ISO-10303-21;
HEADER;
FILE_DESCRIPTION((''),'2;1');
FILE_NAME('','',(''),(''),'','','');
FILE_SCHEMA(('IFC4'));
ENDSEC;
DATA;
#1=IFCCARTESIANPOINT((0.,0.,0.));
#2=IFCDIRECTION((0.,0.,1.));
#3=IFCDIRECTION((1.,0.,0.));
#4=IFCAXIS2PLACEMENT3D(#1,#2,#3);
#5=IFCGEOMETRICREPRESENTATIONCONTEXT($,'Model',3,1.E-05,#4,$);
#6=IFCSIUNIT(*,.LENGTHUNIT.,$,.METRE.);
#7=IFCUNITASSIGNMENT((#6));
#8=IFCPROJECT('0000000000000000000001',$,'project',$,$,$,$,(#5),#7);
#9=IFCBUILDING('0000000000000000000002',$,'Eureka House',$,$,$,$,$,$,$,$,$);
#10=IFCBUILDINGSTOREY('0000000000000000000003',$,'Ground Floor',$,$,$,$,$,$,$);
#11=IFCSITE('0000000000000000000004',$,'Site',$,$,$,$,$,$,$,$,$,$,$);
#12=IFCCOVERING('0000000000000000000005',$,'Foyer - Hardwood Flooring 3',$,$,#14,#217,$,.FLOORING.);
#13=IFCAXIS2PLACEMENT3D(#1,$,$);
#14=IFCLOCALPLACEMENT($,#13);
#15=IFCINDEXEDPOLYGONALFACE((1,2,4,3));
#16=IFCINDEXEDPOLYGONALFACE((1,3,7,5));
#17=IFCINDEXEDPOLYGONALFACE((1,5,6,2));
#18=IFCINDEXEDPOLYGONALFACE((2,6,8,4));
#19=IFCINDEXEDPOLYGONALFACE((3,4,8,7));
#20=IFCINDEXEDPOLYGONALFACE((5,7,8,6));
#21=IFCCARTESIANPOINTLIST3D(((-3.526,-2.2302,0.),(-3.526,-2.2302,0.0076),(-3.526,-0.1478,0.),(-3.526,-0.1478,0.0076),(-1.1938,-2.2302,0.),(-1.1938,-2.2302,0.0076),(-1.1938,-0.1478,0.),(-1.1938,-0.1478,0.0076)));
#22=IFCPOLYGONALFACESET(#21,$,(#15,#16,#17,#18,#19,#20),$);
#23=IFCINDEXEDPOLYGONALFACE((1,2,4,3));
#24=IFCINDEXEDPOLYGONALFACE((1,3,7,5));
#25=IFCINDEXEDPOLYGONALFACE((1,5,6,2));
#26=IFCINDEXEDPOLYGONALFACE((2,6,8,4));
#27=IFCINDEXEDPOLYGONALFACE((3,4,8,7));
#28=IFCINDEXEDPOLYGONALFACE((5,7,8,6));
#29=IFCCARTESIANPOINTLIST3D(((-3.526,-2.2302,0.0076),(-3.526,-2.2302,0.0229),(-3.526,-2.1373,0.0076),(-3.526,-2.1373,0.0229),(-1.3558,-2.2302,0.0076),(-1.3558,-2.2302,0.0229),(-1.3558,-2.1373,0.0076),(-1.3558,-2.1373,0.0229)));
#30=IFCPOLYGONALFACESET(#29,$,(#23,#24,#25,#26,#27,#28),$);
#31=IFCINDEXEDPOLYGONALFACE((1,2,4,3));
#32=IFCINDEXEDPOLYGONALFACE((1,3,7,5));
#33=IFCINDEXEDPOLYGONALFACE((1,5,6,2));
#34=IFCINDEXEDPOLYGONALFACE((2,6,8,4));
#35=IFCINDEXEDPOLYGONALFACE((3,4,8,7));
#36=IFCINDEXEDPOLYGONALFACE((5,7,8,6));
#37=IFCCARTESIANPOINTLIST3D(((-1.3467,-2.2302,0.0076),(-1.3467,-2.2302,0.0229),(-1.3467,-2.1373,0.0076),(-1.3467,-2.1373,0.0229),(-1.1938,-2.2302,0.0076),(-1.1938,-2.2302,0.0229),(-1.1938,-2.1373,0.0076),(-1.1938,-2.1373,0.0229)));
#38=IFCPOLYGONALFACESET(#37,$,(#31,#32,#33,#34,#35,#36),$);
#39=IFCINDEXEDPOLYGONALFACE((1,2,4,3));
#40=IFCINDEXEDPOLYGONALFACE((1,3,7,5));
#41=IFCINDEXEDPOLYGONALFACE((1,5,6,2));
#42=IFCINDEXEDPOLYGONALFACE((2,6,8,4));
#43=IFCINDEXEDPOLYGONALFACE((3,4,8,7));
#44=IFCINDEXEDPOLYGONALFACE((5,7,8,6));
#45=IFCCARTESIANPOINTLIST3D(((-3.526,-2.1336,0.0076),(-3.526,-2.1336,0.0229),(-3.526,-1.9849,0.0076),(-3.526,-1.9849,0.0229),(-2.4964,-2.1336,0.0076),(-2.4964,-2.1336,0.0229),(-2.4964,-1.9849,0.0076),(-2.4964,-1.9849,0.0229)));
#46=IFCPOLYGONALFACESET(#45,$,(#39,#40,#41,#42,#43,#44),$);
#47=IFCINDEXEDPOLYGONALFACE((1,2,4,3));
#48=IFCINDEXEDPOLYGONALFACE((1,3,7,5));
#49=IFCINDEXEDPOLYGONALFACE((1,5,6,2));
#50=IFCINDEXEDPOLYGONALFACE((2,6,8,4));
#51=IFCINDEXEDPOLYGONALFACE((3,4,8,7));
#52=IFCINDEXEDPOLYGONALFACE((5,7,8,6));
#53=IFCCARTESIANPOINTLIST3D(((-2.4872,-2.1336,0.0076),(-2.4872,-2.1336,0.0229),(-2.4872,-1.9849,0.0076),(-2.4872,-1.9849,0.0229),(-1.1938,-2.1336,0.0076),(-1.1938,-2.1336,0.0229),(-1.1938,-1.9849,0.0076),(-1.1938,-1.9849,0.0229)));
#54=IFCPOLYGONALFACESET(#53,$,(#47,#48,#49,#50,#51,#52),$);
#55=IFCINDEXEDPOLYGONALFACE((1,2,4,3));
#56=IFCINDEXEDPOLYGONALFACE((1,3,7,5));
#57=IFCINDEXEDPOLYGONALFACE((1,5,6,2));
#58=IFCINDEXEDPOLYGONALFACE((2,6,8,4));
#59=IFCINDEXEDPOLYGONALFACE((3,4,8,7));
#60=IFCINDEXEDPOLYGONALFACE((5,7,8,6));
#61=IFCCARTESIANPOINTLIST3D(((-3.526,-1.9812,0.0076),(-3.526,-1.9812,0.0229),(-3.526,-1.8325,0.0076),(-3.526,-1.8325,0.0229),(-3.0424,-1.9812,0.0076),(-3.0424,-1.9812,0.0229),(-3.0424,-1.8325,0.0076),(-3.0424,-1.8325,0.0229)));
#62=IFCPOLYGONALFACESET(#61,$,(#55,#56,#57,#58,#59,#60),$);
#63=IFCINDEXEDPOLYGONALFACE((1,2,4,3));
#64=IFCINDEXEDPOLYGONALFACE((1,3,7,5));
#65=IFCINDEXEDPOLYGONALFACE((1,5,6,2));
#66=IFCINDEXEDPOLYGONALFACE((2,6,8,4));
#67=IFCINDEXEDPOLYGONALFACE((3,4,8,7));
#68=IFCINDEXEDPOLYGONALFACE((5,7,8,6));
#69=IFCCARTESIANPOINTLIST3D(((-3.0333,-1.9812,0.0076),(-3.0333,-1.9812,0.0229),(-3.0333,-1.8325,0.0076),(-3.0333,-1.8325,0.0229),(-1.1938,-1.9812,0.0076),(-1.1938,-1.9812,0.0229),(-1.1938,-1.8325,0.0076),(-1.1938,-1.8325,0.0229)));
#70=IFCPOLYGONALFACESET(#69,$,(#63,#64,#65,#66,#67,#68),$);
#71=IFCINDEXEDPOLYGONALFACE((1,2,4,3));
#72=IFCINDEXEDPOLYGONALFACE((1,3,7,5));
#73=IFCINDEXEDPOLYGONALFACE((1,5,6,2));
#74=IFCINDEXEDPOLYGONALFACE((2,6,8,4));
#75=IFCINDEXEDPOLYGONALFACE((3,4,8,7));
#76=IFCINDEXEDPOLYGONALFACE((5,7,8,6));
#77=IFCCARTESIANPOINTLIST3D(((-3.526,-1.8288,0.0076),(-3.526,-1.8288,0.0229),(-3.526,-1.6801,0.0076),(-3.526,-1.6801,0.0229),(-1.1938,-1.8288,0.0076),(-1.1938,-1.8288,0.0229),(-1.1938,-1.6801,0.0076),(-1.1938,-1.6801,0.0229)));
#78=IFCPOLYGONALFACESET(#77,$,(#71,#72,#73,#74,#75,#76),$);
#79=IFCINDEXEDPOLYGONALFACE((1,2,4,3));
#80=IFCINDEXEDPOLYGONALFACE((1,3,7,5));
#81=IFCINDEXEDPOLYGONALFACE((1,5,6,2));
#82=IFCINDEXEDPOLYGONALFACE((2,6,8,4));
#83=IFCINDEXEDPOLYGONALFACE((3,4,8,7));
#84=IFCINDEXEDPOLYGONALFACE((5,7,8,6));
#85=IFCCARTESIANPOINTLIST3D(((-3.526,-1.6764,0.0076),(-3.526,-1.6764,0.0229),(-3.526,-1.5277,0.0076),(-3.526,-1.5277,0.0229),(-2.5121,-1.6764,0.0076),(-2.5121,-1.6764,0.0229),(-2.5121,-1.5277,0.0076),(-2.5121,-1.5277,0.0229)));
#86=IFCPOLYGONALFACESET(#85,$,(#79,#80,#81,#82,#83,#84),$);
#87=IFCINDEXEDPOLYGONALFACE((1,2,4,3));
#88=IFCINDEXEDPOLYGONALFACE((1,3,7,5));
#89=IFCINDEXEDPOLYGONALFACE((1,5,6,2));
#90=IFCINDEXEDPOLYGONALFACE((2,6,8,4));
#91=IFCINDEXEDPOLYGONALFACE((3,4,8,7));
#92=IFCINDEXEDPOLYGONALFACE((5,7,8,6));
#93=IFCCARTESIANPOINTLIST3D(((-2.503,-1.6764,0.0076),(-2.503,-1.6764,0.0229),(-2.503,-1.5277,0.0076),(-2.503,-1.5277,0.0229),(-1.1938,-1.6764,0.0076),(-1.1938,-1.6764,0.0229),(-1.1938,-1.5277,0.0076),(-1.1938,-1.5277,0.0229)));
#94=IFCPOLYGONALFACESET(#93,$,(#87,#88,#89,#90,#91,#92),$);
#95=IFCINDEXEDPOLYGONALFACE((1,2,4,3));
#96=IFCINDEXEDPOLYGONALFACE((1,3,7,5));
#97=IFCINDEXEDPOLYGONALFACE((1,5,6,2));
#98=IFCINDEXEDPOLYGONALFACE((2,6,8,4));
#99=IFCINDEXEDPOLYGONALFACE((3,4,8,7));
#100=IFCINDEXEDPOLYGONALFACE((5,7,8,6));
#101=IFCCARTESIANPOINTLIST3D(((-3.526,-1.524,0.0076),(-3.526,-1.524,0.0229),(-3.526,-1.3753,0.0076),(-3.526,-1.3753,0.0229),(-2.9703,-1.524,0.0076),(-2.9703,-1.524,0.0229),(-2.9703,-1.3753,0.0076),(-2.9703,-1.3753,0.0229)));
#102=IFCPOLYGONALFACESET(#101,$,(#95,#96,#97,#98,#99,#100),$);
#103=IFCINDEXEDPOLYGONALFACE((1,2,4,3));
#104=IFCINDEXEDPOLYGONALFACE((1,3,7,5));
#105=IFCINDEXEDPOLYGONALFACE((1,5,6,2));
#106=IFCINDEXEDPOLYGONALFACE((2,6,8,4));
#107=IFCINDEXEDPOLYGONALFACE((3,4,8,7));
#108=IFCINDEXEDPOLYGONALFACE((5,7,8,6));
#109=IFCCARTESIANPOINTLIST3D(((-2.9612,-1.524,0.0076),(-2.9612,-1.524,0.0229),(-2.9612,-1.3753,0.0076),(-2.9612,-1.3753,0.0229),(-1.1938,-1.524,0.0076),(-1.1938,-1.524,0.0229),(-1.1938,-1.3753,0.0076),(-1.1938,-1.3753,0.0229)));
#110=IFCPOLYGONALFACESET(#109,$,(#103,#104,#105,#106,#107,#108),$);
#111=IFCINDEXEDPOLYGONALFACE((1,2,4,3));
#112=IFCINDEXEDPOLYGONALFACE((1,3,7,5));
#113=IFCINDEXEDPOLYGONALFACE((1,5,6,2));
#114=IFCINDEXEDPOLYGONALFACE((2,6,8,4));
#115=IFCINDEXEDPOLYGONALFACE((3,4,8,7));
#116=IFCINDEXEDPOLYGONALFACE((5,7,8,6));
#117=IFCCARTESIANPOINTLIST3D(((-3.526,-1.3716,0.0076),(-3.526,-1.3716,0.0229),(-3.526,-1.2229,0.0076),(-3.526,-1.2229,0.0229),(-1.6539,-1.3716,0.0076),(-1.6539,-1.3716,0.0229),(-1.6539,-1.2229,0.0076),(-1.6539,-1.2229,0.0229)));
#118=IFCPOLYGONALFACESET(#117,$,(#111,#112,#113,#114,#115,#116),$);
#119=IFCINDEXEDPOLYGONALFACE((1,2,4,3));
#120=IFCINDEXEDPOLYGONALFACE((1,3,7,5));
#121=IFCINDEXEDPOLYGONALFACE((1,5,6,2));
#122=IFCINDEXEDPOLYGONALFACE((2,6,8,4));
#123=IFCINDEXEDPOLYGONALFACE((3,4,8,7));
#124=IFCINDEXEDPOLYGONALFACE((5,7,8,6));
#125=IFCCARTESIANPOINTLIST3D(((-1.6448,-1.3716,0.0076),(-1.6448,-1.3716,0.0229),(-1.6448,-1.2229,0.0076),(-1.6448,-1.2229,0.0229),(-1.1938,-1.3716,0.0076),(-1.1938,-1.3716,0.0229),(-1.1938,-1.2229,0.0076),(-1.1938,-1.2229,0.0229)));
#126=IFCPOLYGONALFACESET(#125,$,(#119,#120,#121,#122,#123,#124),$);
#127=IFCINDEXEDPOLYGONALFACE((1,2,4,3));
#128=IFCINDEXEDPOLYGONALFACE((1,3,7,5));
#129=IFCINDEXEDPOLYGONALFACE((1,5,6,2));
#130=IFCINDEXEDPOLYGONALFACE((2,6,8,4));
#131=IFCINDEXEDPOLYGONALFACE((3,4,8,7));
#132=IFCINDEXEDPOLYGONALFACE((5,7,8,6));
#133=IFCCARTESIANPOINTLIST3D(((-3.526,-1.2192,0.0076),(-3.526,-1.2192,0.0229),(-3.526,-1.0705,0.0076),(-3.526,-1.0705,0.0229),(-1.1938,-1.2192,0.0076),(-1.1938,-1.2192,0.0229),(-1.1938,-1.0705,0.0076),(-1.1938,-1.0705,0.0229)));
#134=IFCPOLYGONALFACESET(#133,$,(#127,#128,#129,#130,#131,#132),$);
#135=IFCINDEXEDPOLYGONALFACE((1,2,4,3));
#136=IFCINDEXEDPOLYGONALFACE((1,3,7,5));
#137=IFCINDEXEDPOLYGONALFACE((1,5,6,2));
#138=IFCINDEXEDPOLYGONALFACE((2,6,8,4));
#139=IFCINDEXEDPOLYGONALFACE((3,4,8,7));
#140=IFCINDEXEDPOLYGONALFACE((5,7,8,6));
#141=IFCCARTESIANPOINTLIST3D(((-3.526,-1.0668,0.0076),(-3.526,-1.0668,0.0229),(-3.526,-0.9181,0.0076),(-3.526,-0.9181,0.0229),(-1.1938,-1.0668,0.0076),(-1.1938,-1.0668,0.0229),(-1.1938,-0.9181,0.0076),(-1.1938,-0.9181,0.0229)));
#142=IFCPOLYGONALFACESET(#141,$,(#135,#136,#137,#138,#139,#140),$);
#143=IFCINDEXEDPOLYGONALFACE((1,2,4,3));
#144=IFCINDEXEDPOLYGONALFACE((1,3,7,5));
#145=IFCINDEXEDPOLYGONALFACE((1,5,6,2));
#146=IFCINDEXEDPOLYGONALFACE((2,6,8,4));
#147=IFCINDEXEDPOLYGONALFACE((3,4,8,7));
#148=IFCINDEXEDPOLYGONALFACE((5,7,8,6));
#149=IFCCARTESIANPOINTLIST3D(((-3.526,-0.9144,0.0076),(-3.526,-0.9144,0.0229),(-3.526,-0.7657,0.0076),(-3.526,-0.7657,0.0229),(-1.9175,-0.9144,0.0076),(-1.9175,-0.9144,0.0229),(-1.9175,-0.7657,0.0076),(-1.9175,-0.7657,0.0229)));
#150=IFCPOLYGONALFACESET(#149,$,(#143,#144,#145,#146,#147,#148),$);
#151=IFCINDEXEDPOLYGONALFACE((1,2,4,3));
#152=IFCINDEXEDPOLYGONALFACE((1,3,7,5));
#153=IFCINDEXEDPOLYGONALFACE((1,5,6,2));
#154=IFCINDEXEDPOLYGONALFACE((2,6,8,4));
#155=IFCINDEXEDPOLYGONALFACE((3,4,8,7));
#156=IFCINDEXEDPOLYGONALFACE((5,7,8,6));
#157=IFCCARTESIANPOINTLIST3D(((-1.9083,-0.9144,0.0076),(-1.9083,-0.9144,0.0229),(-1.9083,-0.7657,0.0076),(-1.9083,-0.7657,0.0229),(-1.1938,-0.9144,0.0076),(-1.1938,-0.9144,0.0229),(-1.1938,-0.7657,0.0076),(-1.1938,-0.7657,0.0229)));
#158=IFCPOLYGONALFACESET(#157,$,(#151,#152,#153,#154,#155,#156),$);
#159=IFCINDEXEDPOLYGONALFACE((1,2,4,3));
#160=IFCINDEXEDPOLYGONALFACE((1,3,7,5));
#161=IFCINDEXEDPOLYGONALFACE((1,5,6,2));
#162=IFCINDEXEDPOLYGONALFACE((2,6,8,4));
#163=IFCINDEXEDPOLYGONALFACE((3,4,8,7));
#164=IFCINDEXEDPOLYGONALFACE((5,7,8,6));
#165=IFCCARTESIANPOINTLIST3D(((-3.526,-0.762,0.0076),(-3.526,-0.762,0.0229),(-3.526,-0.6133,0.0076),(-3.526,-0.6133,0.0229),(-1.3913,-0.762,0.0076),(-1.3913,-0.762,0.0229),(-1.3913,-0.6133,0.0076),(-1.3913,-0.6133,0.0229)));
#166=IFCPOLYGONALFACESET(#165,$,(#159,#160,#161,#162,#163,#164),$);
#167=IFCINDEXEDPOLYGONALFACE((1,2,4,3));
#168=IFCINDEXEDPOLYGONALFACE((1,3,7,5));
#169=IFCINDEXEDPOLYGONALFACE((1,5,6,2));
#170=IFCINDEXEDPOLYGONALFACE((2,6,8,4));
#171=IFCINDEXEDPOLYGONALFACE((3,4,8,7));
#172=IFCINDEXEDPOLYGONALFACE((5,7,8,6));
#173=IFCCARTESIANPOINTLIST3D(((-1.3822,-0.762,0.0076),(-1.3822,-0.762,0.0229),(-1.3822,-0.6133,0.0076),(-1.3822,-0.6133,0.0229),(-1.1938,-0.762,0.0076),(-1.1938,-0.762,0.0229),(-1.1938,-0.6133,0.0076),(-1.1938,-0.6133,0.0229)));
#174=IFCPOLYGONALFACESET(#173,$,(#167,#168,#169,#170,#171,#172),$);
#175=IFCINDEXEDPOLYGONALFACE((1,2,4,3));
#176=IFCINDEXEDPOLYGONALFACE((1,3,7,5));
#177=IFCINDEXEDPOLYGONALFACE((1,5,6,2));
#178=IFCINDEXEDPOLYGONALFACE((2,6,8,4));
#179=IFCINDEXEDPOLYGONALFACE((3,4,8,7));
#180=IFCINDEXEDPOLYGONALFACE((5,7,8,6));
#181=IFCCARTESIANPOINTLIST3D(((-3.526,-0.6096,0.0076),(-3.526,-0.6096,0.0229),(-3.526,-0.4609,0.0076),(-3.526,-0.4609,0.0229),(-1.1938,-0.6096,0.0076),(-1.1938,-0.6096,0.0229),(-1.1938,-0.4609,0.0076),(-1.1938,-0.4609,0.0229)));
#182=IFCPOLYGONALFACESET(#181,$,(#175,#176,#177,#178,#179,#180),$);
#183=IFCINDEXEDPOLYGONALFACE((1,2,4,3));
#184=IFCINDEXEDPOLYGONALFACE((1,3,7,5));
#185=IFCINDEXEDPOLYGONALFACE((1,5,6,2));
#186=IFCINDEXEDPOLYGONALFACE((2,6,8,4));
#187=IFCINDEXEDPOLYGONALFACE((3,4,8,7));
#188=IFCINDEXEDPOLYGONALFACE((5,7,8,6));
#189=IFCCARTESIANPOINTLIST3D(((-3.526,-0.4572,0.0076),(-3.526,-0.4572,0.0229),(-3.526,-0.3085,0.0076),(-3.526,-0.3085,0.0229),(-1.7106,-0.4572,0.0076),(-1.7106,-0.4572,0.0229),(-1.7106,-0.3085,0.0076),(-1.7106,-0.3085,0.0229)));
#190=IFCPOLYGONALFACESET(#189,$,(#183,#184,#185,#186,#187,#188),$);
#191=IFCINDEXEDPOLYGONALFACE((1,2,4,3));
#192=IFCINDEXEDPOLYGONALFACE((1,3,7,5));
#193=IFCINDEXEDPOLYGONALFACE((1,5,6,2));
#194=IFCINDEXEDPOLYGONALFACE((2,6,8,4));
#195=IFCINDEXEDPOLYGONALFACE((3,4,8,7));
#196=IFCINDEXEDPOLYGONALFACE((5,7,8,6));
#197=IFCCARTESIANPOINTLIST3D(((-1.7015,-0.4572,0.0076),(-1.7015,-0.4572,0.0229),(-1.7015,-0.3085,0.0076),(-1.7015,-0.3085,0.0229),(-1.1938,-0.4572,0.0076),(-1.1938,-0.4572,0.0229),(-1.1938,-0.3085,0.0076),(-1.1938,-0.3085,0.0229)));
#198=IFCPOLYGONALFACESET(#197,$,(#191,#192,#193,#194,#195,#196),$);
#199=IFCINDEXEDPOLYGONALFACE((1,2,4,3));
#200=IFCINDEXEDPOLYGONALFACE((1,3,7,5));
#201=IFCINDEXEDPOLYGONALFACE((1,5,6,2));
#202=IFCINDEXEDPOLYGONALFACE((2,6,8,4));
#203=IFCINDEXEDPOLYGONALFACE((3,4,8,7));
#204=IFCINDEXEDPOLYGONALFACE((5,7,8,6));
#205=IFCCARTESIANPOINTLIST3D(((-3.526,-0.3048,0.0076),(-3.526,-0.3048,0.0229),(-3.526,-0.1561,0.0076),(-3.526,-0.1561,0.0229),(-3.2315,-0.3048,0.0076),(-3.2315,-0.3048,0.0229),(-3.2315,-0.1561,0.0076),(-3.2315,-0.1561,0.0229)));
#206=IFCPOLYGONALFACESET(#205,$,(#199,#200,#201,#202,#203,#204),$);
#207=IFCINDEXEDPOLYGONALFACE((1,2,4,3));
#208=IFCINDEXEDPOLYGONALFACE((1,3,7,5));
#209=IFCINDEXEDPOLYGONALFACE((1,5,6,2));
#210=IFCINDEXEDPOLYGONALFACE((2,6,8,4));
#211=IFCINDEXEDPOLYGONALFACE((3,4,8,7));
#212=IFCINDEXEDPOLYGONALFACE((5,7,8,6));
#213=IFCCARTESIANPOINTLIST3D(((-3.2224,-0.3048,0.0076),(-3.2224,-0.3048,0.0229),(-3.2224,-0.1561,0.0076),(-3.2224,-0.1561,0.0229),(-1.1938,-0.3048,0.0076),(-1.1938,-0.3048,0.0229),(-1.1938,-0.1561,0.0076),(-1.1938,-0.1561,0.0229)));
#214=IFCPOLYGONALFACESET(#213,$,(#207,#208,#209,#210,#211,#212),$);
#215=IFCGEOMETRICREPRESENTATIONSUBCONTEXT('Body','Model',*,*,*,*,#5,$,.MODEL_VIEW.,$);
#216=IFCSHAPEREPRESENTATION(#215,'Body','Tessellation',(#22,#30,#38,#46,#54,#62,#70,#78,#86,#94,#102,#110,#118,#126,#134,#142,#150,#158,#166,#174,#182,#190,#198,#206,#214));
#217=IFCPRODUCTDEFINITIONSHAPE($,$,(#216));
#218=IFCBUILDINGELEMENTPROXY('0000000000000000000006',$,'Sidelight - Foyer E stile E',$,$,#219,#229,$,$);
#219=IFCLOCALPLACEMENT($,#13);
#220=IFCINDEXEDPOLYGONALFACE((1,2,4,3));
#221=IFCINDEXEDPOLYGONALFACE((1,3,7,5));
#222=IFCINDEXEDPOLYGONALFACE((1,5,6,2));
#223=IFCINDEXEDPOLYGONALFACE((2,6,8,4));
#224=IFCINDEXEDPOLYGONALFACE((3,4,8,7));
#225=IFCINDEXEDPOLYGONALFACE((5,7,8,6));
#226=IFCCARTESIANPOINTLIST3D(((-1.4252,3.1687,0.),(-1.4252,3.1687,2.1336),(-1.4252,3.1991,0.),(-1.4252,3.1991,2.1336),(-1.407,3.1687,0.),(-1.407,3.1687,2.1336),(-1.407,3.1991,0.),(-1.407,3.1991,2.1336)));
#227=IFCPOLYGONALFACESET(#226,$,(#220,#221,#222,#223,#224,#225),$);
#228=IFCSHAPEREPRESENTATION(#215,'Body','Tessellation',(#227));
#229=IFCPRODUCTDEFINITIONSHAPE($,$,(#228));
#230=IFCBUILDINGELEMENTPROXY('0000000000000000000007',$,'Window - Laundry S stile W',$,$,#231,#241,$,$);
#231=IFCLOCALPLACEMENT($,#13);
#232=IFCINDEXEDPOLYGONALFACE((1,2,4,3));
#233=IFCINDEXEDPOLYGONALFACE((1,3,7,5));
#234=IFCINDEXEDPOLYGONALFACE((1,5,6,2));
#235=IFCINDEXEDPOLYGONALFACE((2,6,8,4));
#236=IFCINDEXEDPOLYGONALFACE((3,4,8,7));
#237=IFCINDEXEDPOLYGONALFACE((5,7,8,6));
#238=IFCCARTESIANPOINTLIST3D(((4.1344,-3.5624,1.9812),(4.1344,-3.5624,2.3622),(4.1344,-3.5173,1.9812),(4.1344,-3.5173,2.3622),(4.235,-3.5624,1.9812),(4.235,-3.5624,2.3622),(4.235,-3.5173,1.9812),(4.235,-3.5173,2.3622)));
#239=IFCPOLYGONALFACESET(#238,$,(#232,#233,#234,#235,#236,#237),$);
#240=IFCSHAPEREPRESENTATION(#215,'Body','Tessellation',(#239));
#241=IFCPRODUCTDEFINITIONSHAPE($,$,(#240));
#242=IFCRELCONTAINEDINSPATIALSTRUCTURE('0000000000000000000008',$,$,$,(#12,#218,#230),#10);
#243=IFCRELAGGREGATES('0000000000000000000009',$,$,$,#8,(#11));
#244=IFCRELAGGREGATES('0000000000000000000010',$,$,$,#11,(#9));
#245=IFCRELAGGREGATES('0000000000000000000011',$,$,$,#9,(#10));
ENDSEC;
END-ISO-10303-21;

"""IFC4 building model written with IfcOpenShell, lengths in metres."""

from ifc_helpers import new_model, si_unit, frame, origin, origin_with_axes, origin_2d, place, context, subcontext, project, spatial, rectangle, extrude, element, save


model = new_model("IFC4")

# Units and contexts
model_context = context("Model", 3, precision=1e-05, world=origin_with_axes())
body_context = subcontext(model_context, "Body", "Model", "MODEL_VIEW")
ifc_project = project(units=[si_unit("LENGTHUNIT", "METRE")], contexts=[model_context])

# Site, building, storey
site = spatial("IfcSite", under=ifc_project, Name="Site")
building = spatial("IfcBuilding", under=site, Name="Eureka House")
storey = spatial("IfcBuildingStorey", under=building, Name="Ground Floor")

# Covering
covering_1_placement = place(None, origin_with_axes())
element("IfcCovering", 1, at=covering_1_placement, inside=storey, Name="Foyer - Hardwood Flooring 3", PredefinedType="FLOORING", context=body_context, shape_type="SweptSolid", body=[
    extrude(rectangle(XDim=2.3322, YDim=2.0824, at=origin_2d()), frame((-2.3599, -1.189, 0.0)), (0.0, 0.0, 1.0), 0.0076),
    extrude(rectangle(XDim=2.1702, YDim=0.093, at=origin_2d()), frame((-2.4409, -2.1837, 0.0076)), (0.0, 0.0, 1.0), 0.0152),
    extrude(rectangle(XDim=0.1528, YDim=0.093, at=origin_2d()), frame((-1.2702, -2.1837, 0.0076)), (0.0, 0.0, 1.0), 0.0152),
    extrude(rectangle(XDim=1.0296, YDim=0.1487, at=origin_2d()), frame((-3.0112, -2.0592, 0.0076)), (0.0, 0.0, 1.0), 0.0152),
    extrude(rectangle(XDim=1.2934, YDim=0.1487, at=origin_2d()), frame((-1.8405, -2.0592, 0.0076)), (0.0, 0.0, 1.0), 0.0152),
    extrude(rectangle(XDim=0.4836, YDim=0.1487, at=origin_2d()), frame((-3.2842, -1.9068, 0.0076)), (0.0, 0.0, 1.0), 0.0152),
    extrude(rectangle(XDim=1.8395, YDim=0.1487, at=origin_2d()), frame((-2.1135, -1.9068, 0.0076)), (0.0, 0.0, 1.0), 0.0152),
    extrude(rectangle(XDim=2.3322, YDim=0.1487, at=origin_2d()), frame((-2.3599, -1.7544, 0.0076)), (0.0, 0.0, 1.0), 0.0152),
    extrude(rectangle(XDim=1.0139, YDim=0.1487, at=origin_2d()), frame((-3.0191, -1.602, 0.0076)), (0.0, 0.0, 1.0), 0.0152),
    extrude(rectangle(XDim=1.3092, YDim=0.1487, at=origin_2d()), frame((-1.8484, -1.602, 0.0076)), (0.0, 0.0, 1.0), 0.0152),
    extrude(rectangle(XDim=0.5557, YDim=0.1487, at=origin_2d()), frame((-3.2482, -1.4496, 0.0076)), (0.0, 0.0, 1.0), 0.0152),
    extrude(rectangle(XDim=1.7674, YDim=0.1487, at=origin_2d()), frame((-2.0775, -1.4496, 0.0076)), (0.0, 0.0, 1.0), 0.0152),
    extrude(rectangle(XDim=1.8721, YDim=0.1487, at=origin_2d()), frame((-2.59, -1.2972, 0.0076)), (0.0, 0.0, 1.0), 0.0152),
    extrude(rectangle(XDim=0.451, YDim=0.1487, at=origin_2d()), frame((-1.4193, -1.2972, 0.0076)), (0.0, 0.0, 1.0), 0.0152),
    extrude(rectangle(XDim=2.3322, YDim=0.1487, at=origin_2d()), frame((-2.3599, -1.1448, 0.0076)), (0.0, 0.0, 1.0), 0.0152),
    extrude(rectangle(XDim=2.3322, YDim=0.1487, at=origin_2d()), frame((-2.3599, -0.9924, 0.0076)), (0.0, 0.0, 1.0), 0.0152),
    extrude(rectangle(XDim=1.6086, YDim=0.1487, at=origin_2d()), frame((-2.7217, -0.84, 0.0076)), (0.0, 0.0, 1.0), 0.0152),
    extrude(rectangle(XDim=0.7145, YDim=0.1487, at=origin_2d()), frame((-1.5511, -0.84, 0.0076)), (0.0, 0.0, 1.0), 0.0152),
    extrude(rectangle(XDim=2.1347, YDim=0.1487, at=origin_2d()), frame((-2.4587, -0.6876, 0.0076)), (0.0, 0.0, 1.0), 0.0152),
    extrude(rectangle(XDim=0.1884, YDim=0.1487, at=origin_2d()), frame((-1.288, -0.6876, 0.0076)), (0.0, 0.0, 1.0), 0.0152),
    extrude(rectangle(XDim=2.3322, YDim=0.1487, at=origin_2d()), frame((-2.3599, -0.5352, 0.0076)), (0.0, 0.0, 1.0), 0.0152),
    extrude(rectangle(XDim=1.8154, YDim=0.1487, at=origin_2d()), frame((-2.6183, -0.3828, 0.0076)), (0.0, 0.0, 1.0), 0.0152),
    extrude(rectangle(XDim=0.5077, YDim=0.1487, at=origin_2d()), frame((-1.4476, -0.3828, 0.0076)), (0.0, 0.0, 1.0), 0.0152),
    extrude(rectangle(XDim=0.2945, YDim=0.1487, at=origin_2d()), frame((-3.3788, -0.2304, 0.0076)), (0.0, 0.0, 1.0), 0.0152),
    extrude(rectangle(XDim=2.0286, YDim=0.1487, at=origin_2d()), frame((-2.2081, -0.2304, 0.0076)), (0.0, 0.0, 1.0), 0.0152),
])

# Building element proxies
proxy_1_placement = place(None, frame((-1.4161, 3.1839, 0.0), z_axis=(0.0, 0.0, 1.0), x_axis=(1.0, 0.0, 0.0)))
element("IfcBuildingElementProxy", 2, at=proxy_1_placement, inside=storey, Name="Sidelight - Foyer E stile E", context=body_context, shape_type="SweptSolid", body=[
    extrude(rectangle(XDim=0.0183, YDim=0.0305, at=origin_2d()), origin(), (0.0, 0.0, 1.0), 2.1336),
])
proxy_2_placement = place(None, frame((4.1847, -3.5398, 1.9812), z_axis=(0.0, 0.0, 1.0), x_axis=(1.0, 0.0, 0.0)))
element("IfcBuildingElementProxy", 3, at=proxy_2_placement, inside=storey, Name="Window - Laundry S stile W", context=body_context, shape_type="SweptSolid", body=[
    extrude(rectangle(XDim=0.1006, YDim=0.0451, at=origin_2d()), origin(), (0.0, 0.0, 1.0), 0.381),
])

save(model, "model.ifc")
